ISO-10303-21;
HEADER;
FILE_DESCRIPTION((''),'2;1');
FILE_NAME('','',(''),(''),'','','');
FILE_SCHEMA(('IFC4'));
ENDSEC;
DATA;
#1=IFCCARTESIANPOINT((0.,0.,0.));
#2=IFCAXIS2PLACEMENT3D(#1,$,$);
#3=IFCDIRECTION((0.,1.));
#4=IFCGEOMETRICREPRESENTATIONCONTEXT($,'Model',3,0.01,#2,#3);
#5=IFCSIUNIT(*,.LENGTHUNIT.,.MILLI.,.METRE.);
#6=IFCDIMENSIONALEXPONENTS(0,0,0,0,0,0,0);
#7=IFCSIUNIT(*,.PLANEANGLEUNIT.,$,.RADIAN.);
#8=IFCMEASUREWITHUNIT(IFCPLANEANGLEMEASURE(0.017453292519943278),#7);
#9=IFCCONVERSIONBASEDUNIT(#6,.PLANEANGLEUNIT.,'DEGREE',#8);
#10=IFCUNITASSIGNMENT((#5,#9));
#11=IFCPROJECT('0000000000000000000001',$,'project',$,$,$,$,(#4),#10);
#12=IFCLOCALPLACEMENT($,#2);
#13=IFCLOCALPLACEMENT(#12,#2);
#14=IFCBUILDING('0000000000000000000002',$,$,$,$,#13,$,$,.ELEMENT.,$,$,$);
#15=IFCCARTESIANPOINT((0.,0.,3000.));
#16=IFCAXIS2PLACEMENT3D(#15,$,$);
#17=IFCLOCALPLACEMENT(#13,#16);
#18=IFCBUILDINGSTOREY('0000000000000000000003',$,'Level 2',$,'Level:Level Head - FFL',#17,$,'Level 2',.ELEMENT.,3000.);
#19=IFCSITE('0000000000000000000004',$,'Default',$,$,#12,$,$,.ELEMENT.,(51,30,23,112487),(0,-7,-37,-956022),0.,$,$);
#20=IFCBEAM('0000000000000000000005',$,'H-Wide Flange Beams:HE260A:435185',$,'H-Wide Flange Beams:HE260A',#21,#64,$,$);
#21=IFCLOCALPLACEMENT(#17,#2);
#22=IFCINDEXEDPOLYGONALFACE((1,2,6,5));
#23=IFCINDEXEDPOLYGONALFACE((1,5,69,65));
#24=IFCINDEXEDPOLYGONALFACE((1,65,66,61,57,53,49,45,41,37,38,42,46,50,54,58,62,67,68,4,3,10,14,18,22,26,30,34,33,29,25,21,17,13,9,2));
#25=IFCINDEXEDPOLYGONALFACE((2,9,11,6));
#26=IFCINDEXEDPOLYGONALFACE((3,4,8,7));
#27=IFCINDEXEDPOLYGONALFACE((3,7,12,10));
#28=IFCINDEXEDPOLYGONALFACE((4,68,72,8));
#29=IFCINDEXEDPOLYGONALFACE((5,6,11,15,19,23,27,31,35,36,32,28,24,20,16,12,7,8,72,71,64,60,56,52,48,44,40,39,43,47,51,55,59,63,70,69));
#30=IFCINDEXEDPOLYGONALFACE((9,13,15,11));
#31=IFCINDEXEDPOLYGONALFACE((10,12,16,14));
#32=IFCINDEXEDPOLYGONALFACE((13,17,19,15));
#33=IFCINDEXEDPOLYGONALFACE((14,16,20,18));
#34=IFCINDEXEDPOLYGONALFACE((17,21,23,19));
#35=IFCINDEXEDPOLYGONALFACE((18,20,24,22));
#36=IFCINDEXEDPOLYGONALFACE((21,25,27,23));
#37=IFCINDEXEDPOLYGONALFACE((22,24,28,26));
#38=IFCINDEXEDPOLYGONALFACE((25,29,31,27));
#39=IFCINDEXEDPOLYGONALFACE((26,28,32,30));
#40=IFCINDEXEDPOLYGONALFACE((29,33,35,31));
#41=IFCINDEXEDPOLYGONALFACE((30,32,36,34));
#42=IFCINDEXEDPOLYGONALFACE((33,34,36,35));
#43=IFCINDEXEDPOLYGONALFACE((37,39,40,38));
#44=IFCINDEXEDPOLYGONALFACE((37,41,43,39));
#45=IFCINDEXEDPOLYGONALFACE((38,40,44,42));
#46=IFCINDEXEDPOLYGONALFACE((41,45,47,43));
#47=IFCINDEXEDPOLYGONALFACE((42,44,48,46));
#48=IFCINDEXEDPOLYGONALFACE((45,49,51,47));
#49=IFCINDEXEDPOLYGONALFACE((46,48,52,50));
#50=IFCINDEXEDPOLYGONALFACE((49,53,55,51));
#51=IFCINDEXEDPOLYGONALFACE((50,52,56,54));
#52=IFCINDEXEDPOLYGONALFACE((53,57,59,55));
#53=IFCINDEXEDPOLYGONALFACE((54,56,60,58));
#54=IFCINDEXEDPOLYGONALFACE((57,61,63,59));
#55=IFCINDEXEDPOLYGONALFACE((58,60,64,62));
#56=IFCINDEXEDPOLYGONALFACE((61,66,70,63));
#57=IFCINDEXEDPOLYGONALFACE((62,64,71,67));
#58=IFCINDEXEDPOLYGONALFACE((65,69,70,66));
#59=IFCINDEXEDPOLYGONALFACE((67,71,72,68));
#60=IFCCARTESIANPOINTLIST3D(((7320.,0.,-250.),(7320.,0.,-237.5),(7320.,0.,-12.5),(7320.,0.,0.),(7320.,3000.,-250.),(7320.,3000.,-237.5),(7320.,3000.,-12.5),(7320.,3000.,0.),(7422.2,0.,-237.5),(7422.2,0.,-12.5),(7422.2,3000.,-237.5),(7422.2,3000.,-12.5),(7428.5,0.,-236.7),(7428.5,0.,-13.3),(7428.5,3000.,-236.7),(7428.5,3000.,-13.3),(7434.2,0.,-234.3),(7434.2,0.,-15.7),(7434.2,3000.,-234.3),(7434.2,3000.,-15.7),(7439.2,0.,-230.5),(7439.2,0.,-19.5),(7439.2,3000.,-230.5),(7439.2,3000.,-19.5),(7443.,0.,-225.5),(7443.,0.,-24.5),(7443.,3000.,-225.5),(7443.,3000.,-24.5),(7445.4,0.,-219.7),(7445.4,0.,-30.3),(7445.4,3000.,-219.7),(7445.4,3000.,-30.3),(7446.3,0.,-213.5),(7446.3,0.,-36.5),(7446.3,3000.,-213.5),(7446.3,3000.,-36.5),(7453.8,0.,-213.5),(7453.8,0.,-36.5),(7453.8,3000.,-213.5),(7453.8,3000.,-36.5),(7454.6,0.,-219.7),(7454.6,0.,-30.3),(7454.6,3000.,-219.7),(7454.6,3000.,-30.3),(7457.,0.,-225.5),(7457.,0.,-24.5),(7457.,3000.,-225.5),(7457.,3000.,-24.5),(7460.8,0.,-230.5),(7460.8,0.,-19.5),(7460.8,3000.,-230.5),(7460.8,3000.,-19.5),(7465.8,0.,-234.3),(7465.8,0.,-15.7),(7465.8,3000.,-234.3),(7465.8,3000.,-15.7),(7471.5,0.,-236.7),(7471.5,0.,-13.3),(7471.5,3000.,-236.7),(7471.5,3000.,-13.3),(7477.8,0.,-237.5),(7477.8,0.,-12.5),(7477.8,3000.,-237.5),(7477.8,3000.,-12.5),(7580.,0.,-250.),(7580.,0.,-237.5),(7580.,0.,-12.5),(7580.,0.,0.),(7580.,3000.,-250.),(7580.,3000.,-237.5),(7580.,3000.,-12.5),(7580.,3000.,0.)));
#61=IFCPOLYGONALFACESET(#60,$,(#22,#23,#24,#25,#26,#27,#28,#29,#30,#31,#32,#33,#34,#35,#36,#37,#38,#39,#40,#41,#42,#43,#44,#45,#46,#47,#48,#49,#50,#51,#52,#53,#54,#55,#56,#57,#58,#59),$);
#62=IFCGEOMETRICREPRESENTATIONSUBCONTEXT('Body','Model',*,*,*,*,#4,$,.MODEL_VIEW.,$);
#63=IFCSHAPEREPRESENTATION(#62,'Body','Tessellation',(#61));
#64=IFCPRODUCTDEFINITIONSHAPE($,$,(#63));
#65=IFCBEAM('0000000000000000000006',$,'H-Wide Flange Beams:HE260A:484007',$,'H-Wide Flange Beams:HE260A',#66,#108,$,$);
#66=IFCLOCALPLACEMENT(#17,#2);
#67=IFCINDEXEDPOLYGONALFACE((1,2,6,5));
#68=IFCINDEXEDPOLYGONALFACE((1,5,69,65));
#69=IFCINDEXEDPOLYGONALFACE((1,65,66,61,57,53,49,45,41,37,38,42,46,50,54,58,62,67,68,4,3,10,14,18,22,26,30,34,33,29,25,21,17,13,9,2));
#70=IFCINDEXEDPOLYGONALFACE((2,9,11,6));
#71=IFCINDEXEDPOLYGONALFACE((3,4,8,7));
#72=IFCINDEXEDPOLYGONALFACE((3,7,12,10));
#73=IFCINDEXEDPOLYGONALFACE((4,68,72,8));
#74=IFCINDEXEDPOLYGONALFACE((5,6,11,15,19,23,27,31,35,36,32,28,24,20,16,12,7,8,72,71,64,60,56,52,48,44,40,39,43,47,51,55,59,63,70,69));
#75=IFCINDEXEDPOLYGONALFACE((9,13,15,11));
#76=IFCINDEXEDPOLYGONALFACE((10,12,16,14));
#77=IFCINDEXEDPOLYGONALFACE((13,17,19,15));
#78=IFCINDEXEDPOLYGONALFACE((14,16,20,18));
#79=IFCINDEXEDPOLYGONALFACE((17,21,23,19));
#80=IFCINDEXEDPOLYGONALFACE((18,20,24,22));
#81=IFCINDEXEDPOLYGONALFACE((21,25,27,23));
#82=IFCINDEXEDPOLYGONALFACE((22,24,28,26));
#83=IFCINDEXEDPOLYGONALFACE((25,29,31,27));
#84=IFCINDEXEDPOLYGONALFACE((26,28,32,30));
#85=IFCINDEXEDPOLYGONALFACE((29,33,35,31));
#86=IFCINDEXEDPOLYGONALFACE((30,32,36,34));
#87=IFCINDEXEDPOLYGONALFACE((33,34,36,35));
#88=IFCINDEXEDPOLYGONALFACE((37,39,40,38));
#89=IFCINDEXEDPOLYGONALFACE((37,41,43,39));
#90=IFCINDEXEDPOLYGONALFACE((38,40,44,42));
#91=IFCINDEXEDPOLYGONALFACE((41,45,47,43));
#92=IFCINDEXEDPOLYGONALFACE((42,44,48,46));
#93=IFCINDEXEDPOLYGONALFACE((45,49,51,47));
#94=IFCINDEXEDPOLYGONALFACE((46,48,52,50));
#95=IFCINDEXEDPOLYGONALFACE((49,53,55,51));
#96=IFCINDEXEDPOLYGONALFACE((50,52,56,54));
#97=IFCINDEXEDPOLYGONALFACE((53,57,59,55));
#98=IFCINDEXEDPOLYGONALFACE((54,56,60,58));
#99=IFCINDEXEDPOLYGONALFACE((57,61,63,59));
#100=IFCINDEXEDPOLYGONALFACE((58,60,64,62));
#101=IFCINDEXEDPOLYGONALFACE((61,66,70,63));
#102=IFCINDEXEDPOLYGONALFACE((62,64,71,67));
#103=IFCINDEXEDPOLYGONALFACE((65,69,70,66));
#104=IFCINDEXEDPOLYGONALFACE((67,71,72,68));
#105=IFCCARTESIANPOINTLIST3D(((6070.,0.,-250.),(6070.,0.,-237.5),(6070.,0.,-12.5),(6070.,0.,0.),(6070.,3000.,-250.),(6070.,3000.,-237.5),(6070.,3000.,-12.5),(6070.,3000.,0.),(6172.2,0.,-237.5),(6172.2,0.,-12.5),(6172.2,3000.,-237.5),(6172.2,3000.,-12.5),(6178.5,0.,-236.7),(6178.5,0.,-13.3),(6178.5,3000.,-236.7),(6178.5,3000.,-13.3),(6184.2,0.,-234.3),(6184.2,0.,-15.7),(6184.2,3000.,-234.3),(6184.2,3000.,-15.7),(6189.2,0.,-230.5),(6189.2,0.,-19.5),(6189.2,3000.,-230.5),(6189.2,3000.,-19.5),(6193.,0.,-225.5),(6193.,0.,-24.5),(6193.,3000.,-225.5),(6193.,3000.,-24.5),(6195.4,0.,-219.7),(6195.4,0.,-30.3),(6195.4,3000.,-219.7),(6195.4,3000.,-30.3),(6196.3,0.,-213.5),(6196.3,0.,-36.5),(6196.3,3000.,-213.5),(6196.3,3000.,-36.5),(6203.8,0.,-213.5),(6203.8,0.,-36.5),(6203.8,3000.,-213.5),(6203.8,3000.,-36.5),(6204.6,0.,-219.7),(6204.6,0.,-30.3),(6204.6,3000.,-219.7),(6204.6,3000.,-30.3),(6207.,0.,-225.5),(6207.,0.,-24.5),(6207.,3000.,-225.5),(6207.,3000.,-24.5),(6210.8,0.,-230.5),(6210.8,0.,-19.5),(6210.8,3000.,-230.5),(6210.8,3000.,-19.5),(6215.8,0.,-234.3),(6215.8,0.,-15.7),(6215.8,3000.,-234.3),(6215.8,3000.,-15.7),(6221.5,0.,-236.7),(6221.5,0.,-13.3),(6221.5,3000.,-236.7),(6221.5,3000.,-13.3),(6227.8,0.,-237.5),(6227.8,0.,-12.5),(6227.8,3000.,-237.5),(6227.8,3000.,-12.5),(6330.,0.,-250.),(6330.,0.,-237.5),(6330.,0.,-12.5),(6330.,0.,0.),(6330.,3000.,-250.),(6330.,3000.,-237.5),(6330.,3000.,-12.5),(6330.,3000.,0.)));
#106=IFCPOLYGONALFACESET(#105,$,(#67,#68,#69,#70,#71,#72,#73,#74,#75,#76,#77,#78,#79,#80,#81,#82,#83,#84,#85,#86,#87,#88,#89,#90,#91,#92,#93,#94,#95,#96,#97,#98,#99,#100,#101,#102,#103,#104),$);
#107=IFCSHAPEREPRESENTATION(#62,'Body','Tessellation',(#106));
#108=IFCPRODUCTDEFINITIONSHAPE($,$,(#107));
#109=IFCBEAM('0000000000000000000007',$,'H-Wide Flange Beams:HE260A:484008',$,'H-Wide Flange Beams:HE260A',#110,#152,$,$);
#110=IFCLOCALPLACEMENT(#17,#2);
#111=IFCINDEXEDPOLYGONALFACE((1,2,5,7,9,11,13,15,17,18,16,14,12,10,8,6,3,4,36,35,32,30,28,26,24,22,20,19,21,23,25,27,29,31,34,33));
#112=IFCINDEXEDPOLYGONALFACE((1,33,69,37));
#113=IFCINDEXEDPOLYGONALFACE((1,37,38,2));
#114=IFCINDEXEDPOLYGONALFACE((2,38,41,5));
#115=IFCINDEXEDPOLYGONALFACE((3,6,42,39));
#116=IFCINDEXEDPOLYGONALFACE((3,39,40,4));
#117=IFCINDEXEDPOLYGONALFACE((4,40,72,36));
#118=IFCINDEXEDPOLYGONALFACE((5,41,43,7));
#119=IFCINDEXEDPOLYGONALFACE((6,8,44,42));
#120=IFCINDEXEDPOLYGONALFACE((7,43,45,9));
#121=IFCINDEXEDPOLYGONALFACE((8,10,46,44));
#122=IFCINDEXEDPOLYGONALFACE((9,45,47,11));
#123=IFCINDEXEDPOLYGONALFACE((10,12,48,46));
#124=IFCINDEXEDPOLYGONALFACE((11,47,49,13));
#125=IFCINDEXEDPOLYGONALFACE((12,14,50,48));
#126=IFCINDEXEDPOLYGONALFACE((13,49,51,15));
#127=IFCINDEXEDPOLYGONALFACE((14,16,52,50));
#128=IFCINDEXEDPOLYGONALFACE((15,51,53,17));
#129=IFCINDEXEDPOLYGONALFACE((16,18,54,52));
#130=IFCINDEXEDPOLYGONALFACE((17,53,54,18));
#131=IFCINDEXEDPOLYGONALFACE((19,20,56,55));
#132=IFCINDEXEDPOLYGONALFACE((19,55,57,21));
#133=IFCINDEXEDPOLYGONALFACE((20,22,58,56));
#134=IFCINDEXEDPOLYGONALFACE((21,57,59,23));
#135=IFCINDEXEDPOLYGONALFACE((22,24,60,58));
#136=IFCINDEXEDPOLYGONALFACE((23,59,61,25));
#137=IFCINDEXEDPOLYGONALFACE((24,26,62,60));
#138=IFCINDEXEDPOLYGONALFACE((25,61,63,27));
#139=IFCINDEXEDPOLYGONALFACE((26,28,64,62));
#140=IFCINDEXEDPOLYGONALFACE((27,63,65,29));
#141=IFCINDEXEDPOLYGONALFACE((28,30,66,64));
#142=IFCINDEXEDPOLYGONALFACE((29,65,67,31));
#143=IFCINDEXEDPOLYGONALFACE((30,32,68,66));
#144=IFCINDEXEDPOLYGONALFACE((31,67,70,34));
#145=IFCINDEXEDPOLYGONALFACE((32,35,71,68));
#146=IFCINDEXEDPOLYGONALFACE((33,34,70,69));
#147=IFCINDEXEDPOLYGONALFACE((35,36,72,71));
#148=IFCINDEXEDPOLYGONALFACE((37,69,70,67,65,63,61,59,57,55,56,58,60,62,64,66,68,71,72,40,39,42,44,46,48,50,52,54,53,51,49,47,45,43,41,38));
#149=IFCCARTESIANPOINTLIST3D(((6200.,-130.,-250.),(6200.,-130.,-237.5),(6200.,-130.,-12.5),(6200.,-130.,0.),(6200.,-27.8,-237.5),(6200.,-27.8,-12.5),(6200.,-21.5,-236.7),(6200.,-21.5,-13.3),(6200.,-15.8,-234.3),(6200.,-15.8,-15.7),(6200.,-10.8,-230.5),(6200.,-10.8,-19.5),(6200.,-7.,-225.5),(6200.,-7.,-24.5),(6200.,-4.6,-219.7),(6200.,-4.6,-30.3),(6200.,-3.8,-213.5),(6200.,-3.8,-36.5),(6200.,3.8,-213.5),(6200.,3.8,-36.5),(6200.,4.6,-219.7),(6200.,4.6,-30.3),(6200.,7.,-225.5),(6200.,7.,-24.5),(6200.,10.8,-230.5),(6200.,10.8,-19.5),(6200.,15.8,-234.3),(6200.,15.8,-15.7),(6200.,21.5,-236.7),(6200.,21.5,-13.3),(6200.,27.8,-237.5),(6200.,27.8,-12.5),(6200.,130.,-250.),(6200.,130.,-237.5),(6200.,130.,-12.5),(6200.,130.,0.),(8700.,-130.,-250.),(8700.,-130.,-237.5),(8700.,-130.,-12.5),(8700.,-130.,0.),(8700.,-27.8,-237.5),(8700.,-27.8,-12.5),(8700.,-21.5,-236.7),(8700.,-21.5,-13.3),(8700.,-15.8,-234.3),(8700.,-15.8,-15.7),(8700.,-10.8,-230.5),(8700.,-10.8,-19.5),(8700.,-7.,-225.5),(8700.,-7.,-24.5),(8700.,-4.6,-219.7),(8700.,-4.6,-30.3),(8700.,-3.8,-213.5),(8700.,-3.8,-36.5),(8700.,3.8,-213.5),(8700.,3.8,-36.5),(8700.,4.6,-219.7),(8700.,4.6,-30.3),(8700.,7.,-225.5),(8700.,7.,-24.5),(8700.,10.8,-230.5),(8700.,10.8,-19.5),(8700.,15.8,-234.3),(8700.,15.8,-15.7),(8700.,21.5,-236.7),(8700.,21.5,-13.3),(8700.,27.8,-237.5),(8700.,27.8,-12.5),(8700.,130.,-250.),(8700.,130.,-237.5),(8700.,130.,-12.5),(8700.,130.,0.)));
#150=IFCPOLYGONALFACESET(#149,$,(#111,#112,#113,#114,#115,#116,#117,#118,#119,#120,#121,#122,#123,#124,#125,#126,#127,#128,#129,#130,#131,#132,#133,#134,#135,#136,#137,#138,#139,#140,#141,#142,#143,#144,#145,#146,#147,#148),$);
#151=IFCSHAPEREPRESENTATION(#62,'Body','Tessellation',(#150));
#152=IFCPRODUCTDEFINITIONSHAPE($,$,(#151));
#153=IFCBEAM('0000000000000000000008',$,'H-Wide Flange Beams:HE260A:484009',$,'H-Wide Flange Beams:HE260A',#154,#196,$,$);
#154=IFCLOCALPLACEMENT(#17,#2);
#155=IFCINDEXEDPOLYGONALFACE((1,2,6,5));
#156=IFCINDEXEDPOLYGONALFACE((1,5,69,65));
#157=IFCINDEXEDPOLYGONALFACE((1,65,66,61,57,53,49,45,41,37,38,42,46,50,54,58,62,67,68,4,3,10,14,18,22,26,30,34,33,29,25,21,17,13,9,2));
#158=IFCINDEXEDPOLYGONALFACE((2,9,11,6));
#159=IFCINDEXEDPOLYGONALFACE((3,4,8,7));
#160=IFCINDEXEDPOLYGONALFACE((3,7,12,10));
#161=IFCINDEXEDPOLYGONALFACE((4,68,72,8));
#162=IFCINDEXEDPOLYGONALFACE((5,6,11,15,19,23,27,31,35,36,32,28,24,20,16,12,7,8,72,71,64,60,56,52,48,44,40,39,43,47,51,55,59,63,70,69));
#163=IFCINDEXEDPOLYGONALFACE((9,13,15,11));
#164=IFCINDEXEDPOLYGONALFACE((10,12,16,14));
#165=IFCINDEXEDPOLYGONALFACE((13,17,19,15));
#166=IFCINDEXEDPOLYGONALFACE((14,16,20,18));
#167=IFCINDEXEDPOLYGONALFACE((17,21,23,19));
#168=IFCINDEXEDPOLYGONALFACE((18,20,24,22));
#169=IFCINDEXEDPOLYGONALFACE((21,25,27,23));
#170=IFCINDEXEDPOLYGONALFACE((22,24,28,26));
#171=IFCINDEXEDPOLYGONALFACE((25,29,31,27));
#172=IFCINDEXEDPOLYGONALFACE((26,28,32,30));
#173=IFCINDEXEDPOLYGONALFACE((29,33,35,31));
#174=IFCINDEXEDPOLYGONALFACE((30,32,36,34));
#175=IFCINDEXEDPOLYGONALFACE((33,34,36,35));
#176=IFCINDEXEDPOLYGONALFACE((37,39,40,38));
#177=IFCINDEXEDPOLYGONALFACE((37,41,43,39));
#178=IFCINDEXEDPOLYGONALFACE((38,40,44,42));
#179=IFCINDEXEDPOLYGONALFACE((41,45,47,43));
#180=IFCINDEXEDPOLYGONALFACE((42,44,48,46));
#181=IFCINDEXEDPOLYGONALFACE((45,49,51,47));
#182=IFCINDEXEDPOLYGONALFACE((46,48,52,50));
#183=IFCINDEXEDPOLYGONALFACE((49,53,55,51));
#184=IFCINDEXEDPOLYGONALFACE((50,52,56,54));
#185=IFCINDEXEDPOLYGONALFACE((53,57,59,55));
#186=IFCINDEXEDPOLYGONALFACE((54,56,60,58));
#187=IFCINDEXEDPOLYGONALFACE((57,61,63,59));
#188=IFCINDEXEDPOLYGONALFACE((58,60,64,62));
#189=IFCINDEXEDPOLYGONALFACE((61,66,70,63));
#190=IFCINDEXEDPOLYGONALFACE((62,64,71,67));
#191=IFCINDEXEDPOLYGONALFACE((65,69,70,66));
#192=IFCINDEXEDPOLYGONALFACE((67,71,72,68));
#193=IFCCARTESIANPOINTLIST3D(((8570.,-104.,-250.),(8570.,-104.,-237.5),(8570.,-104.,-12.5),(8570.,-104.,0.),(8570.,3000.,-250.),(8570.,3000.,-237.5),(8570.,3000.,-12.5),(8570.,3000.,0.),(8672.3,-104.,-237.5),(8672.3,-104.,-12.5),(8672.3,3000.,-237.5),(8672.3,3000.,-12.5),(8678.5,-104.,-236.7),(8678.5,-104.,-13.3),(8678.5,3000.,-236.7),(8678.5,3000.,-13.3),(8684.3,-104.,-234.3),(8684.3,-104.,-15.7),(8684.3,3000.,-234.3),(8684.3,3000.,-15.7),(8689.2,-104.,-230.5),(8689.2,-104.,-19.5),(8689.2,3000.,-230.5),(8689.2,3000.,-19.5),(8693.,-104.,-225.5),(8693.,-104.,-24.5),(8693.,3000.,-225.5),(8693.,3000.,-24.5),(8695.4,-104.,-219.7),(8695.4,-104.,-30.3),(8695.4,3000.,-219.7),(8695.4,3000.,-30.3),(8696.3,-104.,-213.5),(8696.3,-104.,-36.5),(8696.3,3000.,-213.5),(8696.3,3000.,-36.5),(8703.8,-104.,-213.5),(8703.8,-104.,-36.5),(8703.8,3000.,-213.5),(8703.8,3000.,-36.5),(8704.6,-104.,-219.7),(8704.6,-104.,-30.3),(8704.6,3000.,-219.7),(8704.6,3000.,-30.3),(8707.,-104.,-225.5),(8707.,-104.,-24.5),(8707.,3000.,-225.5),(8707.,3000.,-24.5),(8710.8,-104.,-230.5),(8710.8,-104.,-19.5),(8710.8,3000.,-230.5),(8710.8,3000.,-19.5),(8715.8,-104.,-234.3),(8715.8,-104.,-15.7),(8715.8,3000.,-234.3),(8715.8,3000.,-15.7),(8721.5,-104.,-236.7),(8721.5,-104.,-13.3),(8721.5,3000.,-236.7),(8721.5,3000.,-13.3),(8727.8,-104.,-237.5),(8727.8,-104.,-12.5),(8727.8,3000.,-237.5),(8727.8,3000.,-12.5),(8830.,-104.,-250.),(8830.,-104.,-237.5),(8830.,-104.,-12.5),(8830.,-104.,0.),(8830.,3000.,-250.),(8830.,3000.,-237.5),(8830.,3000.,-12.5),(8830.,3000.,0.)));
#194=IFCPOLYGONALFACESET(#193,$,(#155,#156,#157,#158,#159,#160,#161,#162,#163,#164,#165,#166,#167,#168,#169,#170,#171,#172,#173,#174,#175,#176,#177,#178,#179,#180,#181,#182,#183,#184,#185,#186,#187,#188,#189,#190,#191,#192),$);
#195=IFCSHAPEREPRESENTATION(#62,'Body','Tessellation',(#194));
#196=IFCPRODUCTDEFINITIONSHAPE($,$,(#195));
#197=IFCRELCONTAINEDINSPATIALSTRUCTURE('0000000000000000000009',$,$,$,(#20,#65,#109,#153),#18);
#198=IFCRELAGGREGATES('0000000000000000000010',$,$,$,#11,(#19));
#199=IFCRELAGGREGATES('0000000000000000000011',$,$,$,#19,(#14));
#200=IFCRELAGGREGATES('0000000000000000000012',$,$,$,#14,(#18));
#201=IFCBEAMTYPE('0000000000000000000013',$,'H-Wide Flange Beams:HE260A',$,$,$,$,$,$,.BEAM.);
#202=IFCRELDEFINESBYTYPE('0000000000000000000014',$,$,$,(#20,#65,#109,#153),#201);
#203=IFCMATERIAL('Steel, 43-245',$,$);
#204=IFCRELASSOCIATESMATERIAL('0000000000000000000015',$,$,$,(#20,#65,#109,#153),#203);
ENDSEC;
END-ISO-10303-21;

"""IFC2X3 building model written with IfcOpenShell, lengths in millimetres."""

from ifc_helpers import new_model, entity, si_unit, converted_unit, direction, frame, frame_2d, origin, place, context, subcontext, project, spatial, i_section, extrude, material, type_object, element, save


model = new_model("IFC2X3")

# Units and contexts
model_context = context("Model", 3, precision=0.01, world=origin(), true_north=direction((0.0, 1.0)))
body_context = subcontext(model_context, "Body", "Model", "MODEL_VIEW")
ifc_project = project(units=[si_unit("LENGTHUNIT", "METRE", prefix="MILLI"), converted_unit("PLANEANGLEUNIT", "DEGREE", entity("IfcPlaneAngleMeasure", 0.017453292519943278), si_unit("PLANEANGLEUNIT", "RADIAN"), dimensions=[0, 0, 0, 0, 0, 0, 0])], contexts=[model_context])

# Site, building, storey
site_placement = place(None, origin())
site = spatial("IfcSite", under=ifc_project, at=site_placement, Name="Default", CompositionType="ELEMENT", RefLatitude=(51, 30, 23, 112487), RefLongitude=(0, -7, -37, -956022), RefElevation=0.0)
building_placement = place(site_placement, origin())
building = spatial("IfcBuilding", under=site, at=building_placement, CompositionType="ELEMENT")
storey_placement = place(building_placement, frame((0.0, 0.0, 3000.0)))
storey = spatial("IfcBuildingStorey", under=building, at=storey_placement, Name="Level 2", ObjectType="Level:Level Head - FFL", LongName="Level 2", CompositionType="ELEMENT", Elevation=3000.0)

# Beams
ifc_material = material(Name="Steel, 43-245")
beam_type_1 = type_object("IfcBeamType", Name="H-Wide Flange Beams:HE260A", PredefinedType="BEAM")
beam_1_placement = place(storey_placement, frame((7450.0, 0.0, 0.0), z_axis=(0.0, 0.0, 1.0), x_axis=(0.0, 1.0, 0.0)))
element("IfcBeam", 1, at=beam_1_placement, inside=storey, type_object=beam_type_1, material=ifc_material, Name="H-Wide Flange Beams:HE260A:435185", ObjectType="H-Wide Flange Beams:HE260A", context=body_context, shape_type="SweptSolid", body=[
    extrude(i_section(OverallWidth=260.0, OverallDepth=250.0, WebThickness=7.5, FlangeThickness=12.5, FilletRadius=24.0, at=frame_2d((0.0, 0.0), x_axis=(0.0, 1.0))), frame((0.0, 0.0, -125.0), z_axis=(1.0, 0.0, 0.0), x_axis=(0.0, 0.0, -1.0)), (0.0, 0.0, 1.0), 3000.0),
])
beam_2_placement = place(storey_placement, frame((6200.0, 3000.0, 0.0), z_axis=(0.0, 0.0, 1.0), x_axis=(0.0, -1.0, 0.0)))
element("IfcBeam", 2, at=beam_2_placement, inside=storey, type_object=beam_type_1, material=ifc_material, Name="H-Wide Flange Beams:HE260A:484007", ObjectType="H-Wide Flange Beams:HE260A", context=body_context, shape_type="SweptSolid", body=[
    extrude(i_section(OverallWidth=260.0, OverallDepth=250.0, WebThickness=7.5, FlangeThickness=12.5, FilletRadius=24.0, at=frame_2d((0.0, 0.0), x_axis=(0.0, 1.0))), frame((0.0, 0.0, -125.0), z_axis=(1.0, 0.0, 0.0), x_axis=(0.0, 0.0, -1.0)), (0.0, 0.0, 1.0), 3000.0),
])
beam_3_placement = place(storey_placement, frame((6200.0, 0.0, 0.0)))
element("IfcBeam", 3, at=beam_3_placement, inside=storey, type_object=beam_type_1, material=ifc_material, Name="H-Wide Flange Beams:HE260A:484008", ObjectType="H-Wide Flange Beams:HE260A", context=body_context, shape_type="SweptSolid", body=[
    extrude(i_section(OverallWidth=260.0, OverallDepth=250.0, WebThickness=7.5, FlangeThickness=12.5, FilletRadius=24.0, at=frame_2d((0.0, 0.0), x_axis=(0.0, 1.0))), frame((0.0, 0.0, -125.0), z_axis=(1.0, 0.0, 0.0), x_axis=(0.0, 0.0, -1.0)), (0.0, 0.0, 1.0), 2500.0),
])
beam_4_placement = place(storey_placement, frame((8700.0, 0.0, 0.0), z_axis=(0.0, 0.0, 1.0), x_axis=(0.0, 1.0, 0.0)))
element("IfcBeam", 4, at=beam_4_placement, inside=storey, type_object=beam_type_1, material=ifc_material, Name="H-Wide Flange Beams:HE260A:484009", ObjectType="H-Wide Flange Beams:HE260A", context=body_context, shape_type="SweptSolid", body=[
    extrude(i_section(OverallWidth=260.0, OverallDepth=250.0, WebThickness=7.5, FlangeThickness=12.5, FilletRadius=24.0, at=frame_2d((0.0, 0.0), x_axis=(0.0, 1.0))), frame((-104.0, 0.0, -125.0), z_axis=(1.0, 0.0, 0.0), x_axis=(0.0, 0.0, -1.0)), (0.0, 0.0, 1.0), 3104.0),
])

save(model, "model.ifc")
